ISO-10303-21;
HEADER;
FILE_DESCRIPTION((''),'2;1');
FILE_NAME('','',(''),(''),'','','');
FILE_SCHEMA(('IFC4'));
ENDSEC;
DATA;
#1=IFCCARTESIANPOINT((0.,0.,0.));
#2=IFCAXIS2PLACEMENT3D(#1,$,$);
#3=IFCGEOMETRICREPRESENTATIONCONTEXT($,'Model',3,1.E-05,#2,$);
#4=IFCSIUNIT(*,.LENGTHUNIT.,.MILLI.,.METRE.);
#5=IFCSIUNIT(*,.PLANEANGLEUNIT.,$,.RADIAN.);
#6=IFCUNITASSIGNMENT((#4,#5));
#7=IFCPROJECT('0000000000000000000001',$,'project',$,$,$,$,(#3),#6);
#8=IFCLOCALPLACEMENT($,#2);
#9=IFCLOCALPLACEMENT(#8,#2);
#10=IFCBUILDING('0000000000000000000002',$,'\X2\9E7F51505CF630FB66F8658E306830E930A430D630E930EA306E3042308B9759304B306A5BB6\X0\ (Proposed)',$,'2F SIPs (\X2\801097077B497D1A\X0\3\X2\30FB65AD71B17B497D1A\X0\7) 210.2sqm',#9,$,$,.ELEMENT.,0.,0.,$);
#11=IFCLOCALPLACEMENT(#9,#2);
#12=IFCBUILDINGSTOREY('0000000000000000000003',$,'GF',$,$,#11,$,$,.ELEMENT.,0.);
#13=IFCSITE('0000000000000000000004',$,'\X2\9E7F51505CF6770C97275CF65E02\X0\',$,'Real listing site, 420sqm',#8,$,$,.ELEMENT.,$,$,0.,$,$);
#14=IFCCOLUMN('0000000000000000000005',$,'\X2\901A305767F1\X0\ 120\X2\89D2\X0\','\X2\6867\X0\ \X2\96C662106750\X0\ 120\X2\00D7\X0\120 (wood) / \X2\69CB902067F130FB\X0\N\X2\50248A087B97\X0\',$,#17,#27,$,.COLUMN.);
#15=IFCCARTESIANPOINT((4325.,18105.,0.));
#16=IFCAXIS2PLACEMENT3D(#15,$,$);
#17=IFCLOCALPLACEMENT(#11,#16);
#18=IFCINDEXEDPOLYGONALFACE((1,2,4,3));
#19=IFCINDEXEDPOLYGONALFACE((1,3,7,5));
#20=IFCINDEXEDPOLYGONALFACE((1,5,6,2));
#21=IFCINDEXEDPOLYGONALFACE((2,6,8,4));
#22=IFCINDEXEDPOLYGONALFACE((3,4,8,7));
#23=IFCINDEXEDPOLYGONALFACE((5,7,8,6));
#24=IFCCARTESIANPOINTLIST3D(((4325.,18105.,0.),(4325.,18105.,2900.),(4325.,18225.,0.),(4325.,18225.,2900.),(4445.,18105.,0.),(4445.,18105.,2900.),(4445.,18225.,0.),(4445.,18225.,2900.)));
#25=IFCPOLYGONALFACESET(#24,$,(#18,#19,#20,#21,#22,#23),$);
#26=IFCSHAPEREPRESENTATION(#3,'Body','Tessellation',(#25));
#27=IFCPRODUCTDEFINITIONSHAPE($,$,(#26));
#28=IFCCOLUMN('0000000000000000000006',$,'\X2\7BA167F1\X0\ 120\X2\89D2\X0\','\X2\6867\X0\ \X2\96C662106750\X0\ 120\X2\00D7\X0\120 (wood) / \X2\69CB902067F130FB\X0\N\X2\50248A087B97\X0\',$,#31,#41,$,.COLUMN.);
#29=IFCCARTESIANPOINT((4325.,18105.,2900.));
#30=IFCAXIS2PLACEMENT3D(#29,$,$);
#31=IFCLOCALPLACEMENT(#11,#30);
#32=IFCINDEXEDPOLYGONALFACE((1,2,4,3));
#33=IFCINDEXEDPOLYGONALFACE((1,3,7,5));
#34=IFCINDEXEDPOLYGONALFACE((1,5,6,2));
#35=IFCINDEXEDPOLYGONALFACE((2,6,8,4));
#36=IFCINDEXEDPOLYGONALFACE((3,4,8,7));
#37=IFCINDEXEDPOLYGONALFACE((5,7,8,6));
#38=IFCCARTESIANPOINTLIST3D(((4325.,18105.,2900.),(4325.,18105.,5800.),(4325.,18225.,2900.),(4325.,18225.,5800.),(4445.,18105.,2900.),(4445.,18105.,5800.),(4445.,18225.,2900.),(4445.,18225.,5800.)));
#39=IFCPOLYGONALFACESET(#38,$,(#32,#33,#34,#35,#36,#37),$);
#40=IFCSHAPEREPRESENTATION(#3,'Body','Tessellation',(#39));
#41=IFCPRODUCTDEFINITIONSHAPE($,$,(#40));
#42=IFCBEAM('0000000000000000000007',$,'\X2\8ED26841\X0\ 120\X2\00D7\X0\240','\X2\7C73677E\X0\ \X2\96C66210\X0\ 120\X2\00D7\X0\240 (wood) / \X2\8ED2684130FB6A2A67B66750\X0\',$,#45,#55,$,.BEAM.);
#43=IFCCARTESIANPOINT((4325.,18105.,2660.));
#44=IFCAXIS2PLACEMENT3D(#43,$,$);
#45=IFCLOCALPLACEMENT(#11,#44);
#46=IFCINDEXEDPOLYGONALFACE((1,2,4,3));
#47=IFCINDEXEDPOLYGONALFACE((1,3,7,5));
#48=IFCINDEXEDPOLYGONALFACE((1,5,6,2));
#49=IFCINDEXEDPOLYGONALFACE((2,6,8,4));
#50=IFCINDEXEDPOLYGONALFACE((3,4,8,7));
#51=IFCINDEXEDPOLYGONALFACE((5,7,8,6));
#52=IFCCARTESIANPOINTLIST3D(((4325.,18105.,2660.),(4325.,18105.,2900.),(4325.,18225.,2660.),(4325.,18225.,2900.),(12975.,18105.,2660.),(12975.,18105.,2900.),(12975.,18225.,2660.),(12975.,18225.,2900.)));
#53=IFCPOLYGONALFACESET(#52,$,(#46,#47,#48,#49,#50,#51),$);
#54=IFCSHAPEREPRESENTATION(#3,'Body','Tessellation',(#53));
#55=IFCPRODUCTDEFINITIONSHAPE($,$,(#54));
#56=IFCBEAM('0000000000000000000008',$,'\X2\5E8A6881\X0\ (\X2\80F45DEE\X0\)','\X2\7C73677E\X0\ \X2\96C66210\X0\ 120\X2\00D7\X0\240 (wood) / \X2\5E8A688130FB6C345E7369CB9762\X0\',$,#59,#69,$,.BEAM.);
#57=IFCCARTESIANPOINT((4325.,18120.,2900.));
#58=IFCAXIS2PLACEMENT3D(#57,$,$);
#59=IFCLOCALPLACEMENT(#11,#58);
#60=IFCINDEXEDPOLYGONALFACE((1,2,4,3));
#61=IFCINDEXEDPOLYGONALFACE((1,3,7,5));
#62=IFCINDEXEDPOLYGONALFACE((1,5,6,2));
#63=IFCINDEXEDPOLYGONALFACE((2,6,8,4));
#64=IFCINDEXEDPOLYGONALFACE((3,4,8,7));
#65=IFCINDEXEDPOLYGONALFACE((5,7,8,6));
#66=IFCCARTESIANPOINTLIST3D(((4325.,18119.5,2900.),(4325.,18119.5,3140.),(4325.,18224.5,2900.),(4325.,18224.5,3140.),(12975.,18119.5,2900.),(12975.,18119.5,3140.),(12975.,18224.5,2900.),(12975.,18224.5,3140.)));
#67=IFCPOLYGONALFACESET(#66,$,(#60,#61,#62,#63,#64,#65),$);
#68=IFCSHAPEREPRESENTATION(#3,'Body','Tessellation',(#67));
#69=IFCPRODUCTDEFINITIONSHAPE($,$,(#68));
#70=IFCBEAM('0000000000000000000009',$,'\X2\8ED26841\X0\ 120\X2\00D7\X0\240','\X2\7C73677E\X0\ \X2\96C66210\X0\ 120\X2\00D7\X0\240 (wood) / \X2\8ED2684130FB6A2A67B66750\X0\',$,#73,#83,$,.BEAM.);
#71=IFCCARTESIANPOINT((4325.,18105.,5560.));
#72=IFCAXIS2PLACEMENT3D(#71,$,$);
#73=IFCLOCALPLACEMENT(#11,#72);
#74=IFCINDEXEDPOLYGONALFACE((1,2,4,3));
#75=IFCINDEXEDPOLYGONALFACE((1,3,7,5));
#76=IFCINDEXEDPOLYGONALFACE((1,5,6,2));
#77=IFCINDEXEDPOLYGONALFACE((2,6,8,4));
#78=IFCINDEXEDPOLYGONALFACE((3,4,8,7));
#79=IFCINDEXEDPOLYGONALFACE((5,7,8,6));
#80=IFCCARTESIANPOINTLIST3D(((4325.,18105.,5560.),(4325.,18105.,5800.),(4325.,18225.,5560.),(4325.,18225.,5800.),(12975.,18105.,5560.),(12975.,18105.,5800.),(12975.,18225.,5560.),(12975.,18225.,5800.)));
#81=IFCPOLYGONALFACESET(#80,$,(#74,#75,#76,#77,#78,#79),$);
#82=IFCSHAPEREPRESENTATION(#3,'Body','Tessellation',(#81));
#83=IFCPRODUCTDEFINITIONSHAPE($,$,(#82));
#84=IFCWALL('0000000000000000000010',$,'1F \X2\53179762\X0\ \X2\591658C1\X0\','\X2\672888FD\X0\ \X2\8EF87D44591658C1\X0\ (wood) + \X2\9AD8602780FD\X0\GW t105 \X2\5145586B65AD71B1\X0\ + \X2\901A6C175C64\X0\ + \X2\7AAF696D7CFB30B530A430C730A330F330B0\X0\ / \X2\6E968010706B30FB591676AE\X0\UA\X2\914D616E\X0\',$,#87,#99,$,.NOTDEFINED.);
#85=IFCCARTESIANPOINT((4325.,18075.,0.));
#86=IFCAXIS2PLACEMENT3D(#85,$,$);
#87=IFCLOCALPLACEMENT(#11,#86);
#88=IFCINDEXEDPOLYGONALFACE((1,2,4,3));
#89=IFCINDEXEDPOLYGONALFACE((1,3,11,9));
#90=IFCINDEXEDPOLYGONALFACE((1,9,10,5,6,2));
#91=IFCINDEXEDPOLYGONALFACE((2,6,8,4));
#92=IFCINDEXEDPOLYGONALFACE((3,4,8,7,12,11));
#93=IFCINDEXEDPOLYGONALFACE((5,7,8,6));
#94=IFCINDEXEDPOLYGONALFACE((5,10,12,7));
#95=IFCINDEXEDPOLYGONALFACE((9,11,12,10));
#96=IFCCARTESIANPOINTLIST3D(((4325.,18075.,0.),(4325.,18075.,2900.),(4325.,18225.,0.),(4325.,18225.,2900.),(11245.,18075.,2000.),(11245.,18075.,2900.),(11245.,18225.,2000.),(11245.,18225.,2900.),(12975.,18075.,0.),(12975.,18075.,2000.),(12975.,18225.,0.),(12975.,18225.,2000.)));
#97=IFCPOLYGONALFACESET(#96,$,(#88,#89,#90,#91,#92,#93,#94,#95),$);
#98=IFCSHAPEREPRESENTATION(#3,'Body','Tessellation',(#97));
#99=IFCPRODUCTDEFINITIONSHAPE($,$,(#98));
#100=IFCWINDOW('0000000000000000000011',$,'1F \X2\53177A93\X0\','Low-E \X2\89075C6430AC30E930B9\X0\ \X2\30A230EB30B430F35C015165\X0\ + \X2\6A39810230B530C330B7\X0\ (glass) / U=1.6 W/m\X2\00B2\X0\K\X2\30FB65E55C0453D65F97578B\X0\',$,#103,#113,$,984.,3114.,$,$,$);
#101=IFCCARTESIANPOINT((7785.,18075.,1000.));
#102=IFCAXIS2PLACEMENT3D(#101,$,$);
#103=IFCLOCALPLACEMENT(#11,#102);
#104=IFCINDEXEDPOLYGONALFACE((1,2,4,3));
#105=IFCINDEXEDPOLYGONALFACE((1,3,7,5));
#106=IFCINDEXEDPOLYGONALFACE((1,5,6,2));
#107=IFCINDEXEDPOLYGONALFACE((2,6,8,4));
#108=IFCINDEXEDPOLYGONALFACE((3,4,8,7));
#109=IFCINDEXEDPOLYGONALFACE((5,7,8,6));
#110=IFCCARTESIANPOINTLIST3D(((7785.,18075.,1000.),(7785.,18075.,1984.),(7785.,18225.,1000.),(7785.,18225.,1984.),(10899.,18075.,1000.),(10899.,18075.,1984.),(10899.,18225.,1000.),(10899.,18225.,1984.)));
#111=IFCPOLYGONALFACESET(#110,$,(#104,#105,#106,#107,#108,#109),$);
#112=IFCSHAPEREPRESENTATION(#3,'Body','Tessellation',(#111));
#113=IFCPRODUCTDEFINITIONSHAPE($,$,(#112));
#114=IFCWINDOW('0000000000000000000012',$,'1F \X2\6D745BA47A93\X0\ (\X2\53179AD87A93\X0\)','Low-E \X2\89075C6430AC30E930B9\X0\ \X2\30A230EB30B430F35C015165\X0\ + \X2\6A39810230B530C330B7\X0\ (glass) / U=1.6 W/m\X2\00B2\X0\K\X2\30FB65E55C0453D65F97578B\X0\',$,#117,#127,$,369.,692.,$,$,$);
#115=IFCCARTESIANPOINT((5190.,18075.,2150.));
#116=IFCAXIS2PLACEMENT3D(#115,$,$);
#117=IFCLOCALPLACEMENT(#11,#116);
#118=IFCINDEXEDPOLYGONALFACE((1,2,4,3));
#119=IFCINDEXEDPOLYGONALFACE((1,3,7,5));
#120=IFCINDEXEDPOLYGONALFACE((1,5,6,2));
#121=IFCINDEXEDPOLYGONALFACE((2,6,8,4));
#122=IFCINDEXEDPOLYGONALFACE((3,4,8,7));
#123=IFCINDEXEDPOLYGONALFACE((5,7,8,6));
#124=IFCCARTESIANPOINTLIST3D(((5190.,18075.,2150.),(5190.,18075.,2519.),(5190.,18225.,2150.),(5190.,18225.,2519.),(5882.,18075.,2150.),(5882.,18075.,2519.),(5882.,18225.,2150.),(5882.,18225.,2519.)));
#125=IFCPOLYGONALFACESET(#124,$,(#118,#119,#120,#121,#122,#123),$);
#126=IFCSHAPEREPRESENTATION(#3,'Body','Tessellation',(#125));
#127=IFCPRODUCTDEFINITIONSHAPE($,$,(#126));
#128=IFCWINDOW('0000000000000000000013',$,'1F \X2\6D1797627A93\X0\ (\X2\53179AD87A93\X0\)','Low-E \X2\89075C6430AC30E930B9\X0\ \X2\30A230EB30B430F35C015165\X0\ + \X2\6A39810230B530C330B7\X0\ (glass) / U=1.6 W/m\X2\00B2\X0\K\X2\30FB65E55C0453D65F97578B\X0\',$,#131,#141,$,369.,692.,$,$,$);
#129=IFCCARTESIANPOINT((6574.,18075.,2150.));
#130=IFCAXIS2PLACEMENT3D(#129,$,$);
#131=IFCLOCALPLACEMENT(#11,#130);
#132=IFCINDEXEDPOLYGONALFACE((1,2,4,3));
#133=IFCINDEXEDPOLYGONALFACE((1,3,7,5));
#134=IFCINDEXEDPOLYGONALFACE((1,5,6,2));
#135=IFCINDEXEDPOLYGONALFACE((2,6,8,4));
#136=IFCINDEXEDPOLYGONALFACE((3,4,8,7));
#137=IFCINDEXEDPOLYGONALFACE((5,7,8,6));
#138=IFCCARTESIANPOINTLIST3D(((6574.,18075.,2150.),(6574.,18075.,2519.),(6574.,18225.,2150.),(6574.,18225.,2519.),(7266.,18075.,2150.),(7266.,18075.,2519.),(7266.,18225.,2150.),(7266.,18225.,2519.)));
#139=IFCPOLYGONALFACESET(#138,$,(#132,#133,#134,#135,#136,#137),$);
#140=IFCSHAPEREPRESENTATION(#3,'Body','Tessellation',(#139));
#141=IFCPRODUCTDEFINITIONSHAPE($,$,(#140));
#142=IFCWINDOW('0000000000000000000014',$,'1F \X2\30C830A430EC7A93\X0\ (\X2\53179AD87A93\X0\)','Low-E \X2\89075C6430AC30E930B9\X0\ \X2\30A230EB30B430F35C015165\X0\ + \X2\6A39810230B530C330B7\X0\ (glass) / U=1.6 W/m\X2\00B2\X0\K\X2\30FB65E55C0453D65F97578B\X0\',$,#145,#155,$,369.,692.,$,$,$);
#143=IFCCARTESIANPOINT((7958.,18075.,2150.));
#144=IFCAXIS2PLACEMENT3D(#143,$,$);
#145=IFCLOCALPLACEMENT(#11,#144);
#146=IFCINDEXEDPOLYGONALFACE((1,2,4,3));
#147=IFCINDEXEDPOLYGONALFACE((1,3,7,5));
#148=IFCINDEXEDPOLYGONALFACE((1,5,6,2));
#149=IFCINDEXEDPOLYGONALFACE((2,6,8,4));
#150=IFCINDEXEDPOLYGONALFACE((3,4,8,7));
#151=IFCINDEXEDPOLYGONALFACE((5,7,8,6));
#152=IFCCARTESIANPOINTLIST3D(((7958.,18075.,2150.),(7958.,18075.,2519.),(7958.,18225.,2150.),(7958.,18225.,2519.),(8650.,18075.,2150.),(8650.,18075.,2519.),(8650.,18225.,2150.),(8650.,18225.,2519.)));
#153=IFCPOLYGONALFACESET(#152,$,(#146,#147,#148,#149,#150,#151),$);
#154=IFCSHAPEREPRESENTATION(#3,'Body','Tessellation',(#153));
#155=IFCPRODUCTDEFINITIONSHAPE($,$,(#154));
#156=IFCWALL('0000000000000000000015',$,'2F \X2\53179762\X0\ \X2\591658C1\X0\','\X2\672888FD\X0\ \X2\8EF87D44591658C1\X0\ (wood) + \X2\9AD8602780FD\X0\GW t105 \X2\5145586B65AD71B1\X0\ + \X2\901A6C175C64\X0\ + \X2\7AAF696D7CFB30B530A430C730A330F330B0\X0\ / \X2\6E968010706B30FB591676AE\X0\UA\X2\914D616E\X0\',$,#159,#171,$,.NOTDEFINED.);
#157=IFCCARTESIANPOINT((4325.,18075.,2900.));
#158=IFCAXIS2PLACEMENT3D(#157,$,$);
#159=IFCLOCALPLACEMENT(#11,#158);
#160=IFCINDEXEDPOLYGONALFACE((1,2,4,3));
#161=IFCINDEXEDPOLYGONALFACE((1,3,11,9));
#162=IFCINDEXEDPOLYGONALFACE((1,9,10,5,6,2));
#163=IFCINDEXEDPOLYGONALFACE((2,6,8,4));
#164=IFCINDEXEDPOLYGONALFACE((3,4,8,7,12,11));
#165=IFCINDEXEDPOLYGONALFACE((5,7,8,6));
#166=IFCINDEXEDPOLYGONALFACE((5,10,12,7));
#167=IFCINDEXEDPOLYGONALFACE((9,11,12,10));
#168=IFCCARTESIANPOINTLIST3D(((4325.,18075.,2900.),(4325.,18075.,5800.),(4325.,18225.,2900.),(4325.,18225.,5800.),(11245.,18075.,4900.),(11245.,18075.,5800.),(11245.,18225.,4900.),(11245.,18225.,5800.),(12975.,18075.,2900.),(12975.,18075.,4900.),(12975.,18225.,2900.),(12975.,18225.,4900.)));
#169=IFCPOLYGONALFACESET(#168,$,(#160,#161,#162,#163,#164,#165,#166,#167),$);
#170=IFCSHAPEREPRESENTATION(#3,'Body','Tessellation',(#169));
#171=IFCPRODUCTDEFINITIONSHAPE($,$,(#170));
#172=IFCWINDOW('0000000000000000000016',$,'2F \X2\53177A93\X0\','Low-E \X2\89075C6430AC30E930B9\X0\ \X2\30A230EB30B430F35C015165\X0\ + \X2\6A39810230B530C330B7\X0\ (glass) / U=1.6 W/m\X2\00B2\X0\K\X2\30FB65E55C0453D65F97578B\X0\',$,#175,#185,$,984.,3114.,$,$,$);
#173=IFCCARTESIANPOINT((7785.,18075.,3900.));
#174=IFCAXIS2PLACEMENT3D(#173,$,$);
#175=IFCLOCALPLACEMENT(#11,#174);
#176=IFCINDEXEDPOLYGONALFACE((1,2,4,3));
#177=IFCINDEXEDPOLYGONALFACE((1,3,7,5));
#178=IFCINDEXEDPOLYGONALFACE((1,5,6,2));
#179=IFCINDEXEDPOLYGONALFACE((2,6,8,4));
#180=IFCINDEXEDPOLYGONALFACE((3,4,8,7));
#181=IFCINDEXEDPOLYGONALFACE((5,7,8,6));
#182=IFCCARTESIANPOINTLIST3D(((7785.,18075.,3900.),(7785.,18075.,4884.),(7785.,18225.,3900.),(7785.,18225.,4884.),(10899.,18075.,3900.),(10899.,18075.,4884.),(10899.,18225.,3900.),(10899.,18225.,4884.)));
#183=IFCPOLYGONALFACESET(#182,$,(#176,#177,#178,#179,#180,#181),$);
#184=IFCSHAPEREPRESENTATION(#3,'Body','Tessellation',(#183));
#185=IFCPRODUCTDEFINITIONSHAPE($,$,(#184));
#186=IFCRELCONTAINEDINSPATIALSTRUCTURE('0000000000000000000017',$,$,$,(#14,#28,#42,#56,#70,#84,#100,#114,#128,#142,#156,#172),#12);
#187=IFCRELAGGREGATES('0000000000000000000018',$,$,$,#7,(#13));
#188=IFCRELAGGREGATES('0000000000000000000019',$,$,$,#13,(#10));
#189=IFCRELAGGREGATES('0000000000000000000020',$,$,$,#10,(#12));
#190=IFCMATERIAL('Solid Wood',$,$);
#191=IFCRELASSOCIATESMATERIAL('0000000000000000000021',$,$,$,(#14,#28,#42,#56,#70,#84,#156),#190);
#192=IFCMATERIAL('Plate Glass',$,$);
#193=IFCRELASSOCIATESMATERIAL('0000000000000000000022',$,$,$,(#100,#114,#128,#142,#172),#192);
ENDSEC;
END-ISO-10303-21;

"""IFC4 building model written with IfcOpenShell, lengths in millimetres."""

from ifc_helpers import new_model, si_unit, frame, frame_2d, origin, place, context, project, spatial, rectangle, extrude, material, element, fill, save


model = new_model("IFC4")

# Units and contexts
model_context = context("Model", 3, precision=1e-05, world=origin())
ifc_project = project(units=[si_unit("LENGTHUNIT", "METRE", prefix="MILLI"), si_unit("PLANEANGLEUNIT", "RADIAN")], contexts=[model_context])

# Site, building, storey
site_placement = place(None, origin())
site = spatial("IfcSite", under=ifc_project, at=site_placement, Name="鹿児島県霧島市", ObjectType="Real listing site, 420sqm", CompositionType="ELEMENT", RefElevation=0.0)
building_placement = place(site_placement, origin())
building = spatial("IfcBuilding", under=site, at=building_placement, Name="鹿児島・書斎とライブラリのある静かな家 (Proposed)", ObjectType="2F SIPs (耐震等級3・断熱等級7) 210.2sqm", CompositionType="ELEMENT", ElevationOfRefHeight=0.0, ElevationOfTerrain=0.0)
storey_placement = place(building_placement, origin())
storey = spatial("IfcBuildingStorey", under=building, at=storey_placement, Name="GF", CompositionType="ELEMENT", Elevation=0.0)

# Columns
ifc_material_1 = material(Name="Solid Wood")
column_1_placement = place(storey_placement, frame((4325.0, 18105.0, 0.0)))
element("IfcColumn", 1, at=column_1_placement, inside=storey, material=ifc_material_1, Name="通し柱 120角", Description="桧 集成材 120×120 (wood) / 構造柱・N値計算", PredefinedType="COLUMN", context=model_context, shape_type="SweptSolid", body=[
    extrude(rectangle(XDim=120.0, YDim=120.0, at=frame_2d((60.0, 60.0))), frame((4325.0, 18105.0, 0.0)), (0.0, 0.0, 1.0), 2900.0),
])
column_2_placement = place(storey_placement, frame((4325.0, 18105.0, 2900.0)))
element("IfcColumn", 2, at=column_2_placement, inside=storey, material=ifc_material_1, Name="管柱 120角", Description="桧 集成材 120×120 (wood) / 構造柱・N値計算", PredefinedType="COLUMN", context=model_context, shape_type="SweptSolid", body=[
    extrude(rectangle(XDim=120.0, YDim=120.0, at=frame_2d((60.0, 60.0))), frame((4325.0, 18105.0, 2900.0)), (0.0, 0.0, 1.0), 2900.0),
])

# Beams
beam_1_placement = place(storey_placement, frame((4325.0, 18105.0, 2660.0)))
element("IfcBeam", 3, at=beam_1_placement, inside=storey, material=ifc_material_1, Name="軒桁 120×240", Description="米松 集成 120×240 (wood) / 軒桁・横架材", PredefinedType="BEAM", context=model_context, shape_type="SweptSolid", body=[
    extrude(rectangle(XDim=8650.0, YDim=120.0, at=frame_2d((4325.0, 60.0))), frame((4325.0, 18105.0, 2660.0)), (0.0, 0.0, 1.0), 240.0),
])
beam_2_placement = place(storey_placement, frame((4325.0, 18120.0, 2900.0)))
element("IfcBeam", 4, at=beam_2_placement, inside=storey, material=ifc_material_1, Name="床梁 (胴差)", Description="米松 集成 120×240 (wood) / 床梁・水平構面", PredefinedType="BEAM", context=model_context, shape_type="SweptSolid", body=[
    extrude(rectangle(XDim=8650.0, YDim=105.0, at=frame_2d((4325.0, 52.0))), frame((4325.0, 18120.0, 2900.0)), (0.0, 0.0, 1.0), 240.0),
])
beam_3_placement = place(storey_placement, frame((4325.0, 18105.0, 5560.0)))
element("IfcBeam", 5, at=beam_3_placement, inside=storey, material=ifc_material_1, Name="軒桁 120×240", Description="米松 集成 120×240 (wood) / 軒桁・横架材", PredefinedType="BEAM", context=model_context, shape_type="SweptSolid", body=[
    extrude(rectangle(XDim=8650.0, YDim=120.0, at=frame_2d((4325.0, 60.0))), frame((4325.0, 18105.0, 5560.0)), (0.0, 0.0, 1.0), 240.0),
])

# Wall, openings, windows
wall_1_placement = place(storey_placement, frame((4325.0, 18075.0, 0.0)))
wall_1 = element("IfcWall", 6, at=wall_1_placement, inside=storey, material=ifc_material_1, Name="1F 北面 外壁", Description="木製 軸組外壁 (wood) + 高性能GW t105 充填断熱 + 通気層 + 窯業系サイディング / 準耐火・外皮UA配慮", PredefinedType="NOTDEFINED", context=model_context, shape_type="SweptSolid", body=[
    extrude(rectangle(XDim=8650.0, YDim=150.0, at=frame_2d((4325.0, 75.0))), frame((4325.0, 18075.0, 0.0)), (0.0, 0.0, 1.0), 2900.0),
])
opening_1_placement = place(storey_placement, frame((7785.0, 18075.0, 1000.0)))
opening_1 = element("IfcOpeningElement", 7, at=opening_1_placement, cuts=wall_1, PredefinedType="NOTDEFINED", context=model_context, shape_type="SweptSolid", body=[
    extrude(rectangle(XDim=3114.0, YDim=150.0, at=frame_2d((1557.0, 75.0))), frame((7785.0, 18075.0, 1000.0)), (0.0, 0.0, 1.0), 984.0),
])
opening_2_placement = place(storey_placement, frame((5190.0, 18075.0, 2150.0)))
opening_2 = element("IfcOpeningElement", 8, at=opening_2_placement, cuts=wall_1, PredefinedType="NOTDEFINED", context=model_context, shape_type="SweptSolid", body=[
    extrude(rectangle(XDim=692.0, YDim=150.0, at=frame_2d((346.0, 75.0))), frame((5190.0, 18075.0, 2150.0)), (0.0, 0.0, 1.0), 369.0),
])
opening_3_placement = place(storey_placement, frame((6574.0, 18075.0, 2150.0)))
opening_3 = element("IfcOpeningElement", 9, at=opening_3_placement, cuts=wall_1, PredefinedType="NOTDEFINED", context=model_context, shape_type="SweptSolid", body=[
    extrude(rectangle(XDim=692.0, YDim=150.0, at=frame_2d((346.0, 75.0))), frame((6574.0, 18075.0, 2150.0)), (0.0, 0.0, 1.0), 369.0),
])
opening_4_placement = place(storey_placement, frame((7958.0, 18075.0, 2150.0)))
opening_4 = element("IfcOpeningElement", 10, at=opening_4_placement, cuts=wall_1, PredefinedType="NOTDEFINED", context=model_context, shape_type="SweptSolid", body=[
    extrude(rectangle(XDim=692.0, YDim=150.0, at=frame_2d((346.0, 75.0))), frame((7958.0, 18075.0, 2150.0)), (0.0, 0.0, 1.0), 369.0),
])
ifc_material_2 = material(Name="Plate Glass")
window_1_placement = place(storey_placement, frame((7785.0, 18075.0, 1000.0)))
window_1 = element("IfcWindow", 11, at=window_1_placement, inside=storey, material=ifc_material_2, Name="1F 北窓", Description="Low-E 複層ガラス アルゴン封入 + 樹脂サッシ (glass) / U=1.6 W/m²K・日射取得型", OverallHeight=984.0, OverallWidth=3114.0, context=model_context, shape_type="SweptSolid", body=[
    extrude(rectangle(XDim=3114.0, YDim=150.0, at=frame_2d((1557.0, 75.0))), frame((7785.0, 18075.0, 1000.0)), (0.0, 0.0, 1.0), 984.0),
])
fill(opening_1, window_1)
window_2_placement = place(storey_placement, frame((5190.0, 18075.0, 2150.0)))
window_2 = element("IfcWindow", 12, at=window_2_placement, inside=storey, material=ifc_material_2, Name="1F 浴室窓 (北高窓)", Description="Low-E 複層ガラス アルゴン封入 + 樹脂サッシ (glass) / U=1.6 W/m²K・日射取得型", OverallHeight=369.0, OverallWidth=692.0, context=model_context, shape_type="SweptSolid", body=[
    extrude(rectangle(XDim=692.0, YDim=150.0, at=frame_2d((346.0, 75.0))), frame((5190.0, 18075.0, 2150.0)), (0.0, 0.0, 1.0), 369.0),
])
fill(opening_2, window_2)
window_3_placement = place(storey_placement, frame((6574.0, 18075.0, 2150.0)))
window_3 = element("IfcWindow", 13, at=window_3_placement, inside=storey, material=ifc_material_2, Name="1F 洗面窓 (北高窓)", Description="Low-E 複層ガラス アルゴン封入 + 樹脂サッシ (glass) / U=1.6 W/m²K・日射取得型", OverallHeight=369.0, OverallWidth=692.0, context=model_context, shape_type="SweptSolid", body=[
    extrude(rectangle(XDim=692.0, YDim=150.0, at=frame_2d((346.0, 75.0))), frame((6574.0, 18075.0, 2150.0)), (0.0, 0.0, 1.0), 369.0),
])
fill(opening_3, window_3)
window_4_placement = place(storey_placement, frame((7958.0, 18075.0, 2150.0)))
window_4 = element("IfcWindow", 14, at=window_4_placement, inside=storey, material=ifc_material_2, Name="1F トイレ窓 (北高窓)", Description="Low-E 複層ガラス アルゴン封入 + 樹脂サッシ (glass) / U=1.6 W/m²K・日射取得型", OverallHeight=369.0, OverallWidth=692.0, context=model_context, shape_type="SweptSolid", body=[
    extrude(rectangle(XDim=692.0, YDim=150.0, at=frame_2d((346.0, 75.0))), frame((7958.0, 18075.0, 2150.0)), (0.0, 0.0, 1.0), 369.0),
])
fill(opening_4, window_4)

# Wall, opening, window
wall_2_placement = place(storey_placement, frame((4325.0, 18075.0, 2900.0)))
wall_2 = element("IfcWall", 15, at=wall_2_placement, inside=storey, material=ifc_material_1, Name="2F 北面 外壁", Description="木製 軸組外壁 (wood) + 高性能GW t105 充填断熱 + 通気層 + 窯業系サイディング / 準耐火・外皮UA配慮", PredefinedType="NOTDEFINED", context=model_context, shape_type="SweptSolid", body=[
    extrude(rectangle(XDim=8650.0, YDim=150.0, at=frame_2d((4325.0, 75.0))), frame((4325.0, 18075.0, 2900.0)), (0.0, 0.0, 1.0), 2900.0),
])
opening_5_placement = place(storey_placement, frame((7785.0, 18075.0, 3900.0)))
opening_5 = element("IfcOpeningElement", 16, at=opening_5_placement, cuts=wall_2, PredefinedType="NOTDEFINED", context=model_context, shape_type="SweptSolid", body=[
    extrude(rectangle(XDim=3114.0, YDim=150.0, at=frame_2d((1557.0, 75.0))), frame((7785.0, 18075.0, 3900.0)), (0.0, 0.0, 1.0), 984.0),
])
window_5_placement = place(storey_placement, frame((7785.0, 18075.0, 3900.0)))
window_5 = element("IfcWindow", 17, at=window_5_placement, inside=storey, material=ifc_material_2, Name="2F 北窓", Description="Low-E 複層ガラス アルゴン封入 + 樹脂サッシ (glass) / U=1.6 W/m²K・日射取得型", OverallHeight=984.0, OverallWidth=3114.0, context=model_context, shape_type="SweptSolid", body=[
    extrude(rectangle(XDim=3114.0, YDim=150.0, at=frame_2d((1557.0, 75.0))), frame((7785.0, 18075.0, 3900.0)), (0.0, 0.0, 1.0), 984.0),
])
fill(opening_5, window_5)

save(model, "model.ifc")
